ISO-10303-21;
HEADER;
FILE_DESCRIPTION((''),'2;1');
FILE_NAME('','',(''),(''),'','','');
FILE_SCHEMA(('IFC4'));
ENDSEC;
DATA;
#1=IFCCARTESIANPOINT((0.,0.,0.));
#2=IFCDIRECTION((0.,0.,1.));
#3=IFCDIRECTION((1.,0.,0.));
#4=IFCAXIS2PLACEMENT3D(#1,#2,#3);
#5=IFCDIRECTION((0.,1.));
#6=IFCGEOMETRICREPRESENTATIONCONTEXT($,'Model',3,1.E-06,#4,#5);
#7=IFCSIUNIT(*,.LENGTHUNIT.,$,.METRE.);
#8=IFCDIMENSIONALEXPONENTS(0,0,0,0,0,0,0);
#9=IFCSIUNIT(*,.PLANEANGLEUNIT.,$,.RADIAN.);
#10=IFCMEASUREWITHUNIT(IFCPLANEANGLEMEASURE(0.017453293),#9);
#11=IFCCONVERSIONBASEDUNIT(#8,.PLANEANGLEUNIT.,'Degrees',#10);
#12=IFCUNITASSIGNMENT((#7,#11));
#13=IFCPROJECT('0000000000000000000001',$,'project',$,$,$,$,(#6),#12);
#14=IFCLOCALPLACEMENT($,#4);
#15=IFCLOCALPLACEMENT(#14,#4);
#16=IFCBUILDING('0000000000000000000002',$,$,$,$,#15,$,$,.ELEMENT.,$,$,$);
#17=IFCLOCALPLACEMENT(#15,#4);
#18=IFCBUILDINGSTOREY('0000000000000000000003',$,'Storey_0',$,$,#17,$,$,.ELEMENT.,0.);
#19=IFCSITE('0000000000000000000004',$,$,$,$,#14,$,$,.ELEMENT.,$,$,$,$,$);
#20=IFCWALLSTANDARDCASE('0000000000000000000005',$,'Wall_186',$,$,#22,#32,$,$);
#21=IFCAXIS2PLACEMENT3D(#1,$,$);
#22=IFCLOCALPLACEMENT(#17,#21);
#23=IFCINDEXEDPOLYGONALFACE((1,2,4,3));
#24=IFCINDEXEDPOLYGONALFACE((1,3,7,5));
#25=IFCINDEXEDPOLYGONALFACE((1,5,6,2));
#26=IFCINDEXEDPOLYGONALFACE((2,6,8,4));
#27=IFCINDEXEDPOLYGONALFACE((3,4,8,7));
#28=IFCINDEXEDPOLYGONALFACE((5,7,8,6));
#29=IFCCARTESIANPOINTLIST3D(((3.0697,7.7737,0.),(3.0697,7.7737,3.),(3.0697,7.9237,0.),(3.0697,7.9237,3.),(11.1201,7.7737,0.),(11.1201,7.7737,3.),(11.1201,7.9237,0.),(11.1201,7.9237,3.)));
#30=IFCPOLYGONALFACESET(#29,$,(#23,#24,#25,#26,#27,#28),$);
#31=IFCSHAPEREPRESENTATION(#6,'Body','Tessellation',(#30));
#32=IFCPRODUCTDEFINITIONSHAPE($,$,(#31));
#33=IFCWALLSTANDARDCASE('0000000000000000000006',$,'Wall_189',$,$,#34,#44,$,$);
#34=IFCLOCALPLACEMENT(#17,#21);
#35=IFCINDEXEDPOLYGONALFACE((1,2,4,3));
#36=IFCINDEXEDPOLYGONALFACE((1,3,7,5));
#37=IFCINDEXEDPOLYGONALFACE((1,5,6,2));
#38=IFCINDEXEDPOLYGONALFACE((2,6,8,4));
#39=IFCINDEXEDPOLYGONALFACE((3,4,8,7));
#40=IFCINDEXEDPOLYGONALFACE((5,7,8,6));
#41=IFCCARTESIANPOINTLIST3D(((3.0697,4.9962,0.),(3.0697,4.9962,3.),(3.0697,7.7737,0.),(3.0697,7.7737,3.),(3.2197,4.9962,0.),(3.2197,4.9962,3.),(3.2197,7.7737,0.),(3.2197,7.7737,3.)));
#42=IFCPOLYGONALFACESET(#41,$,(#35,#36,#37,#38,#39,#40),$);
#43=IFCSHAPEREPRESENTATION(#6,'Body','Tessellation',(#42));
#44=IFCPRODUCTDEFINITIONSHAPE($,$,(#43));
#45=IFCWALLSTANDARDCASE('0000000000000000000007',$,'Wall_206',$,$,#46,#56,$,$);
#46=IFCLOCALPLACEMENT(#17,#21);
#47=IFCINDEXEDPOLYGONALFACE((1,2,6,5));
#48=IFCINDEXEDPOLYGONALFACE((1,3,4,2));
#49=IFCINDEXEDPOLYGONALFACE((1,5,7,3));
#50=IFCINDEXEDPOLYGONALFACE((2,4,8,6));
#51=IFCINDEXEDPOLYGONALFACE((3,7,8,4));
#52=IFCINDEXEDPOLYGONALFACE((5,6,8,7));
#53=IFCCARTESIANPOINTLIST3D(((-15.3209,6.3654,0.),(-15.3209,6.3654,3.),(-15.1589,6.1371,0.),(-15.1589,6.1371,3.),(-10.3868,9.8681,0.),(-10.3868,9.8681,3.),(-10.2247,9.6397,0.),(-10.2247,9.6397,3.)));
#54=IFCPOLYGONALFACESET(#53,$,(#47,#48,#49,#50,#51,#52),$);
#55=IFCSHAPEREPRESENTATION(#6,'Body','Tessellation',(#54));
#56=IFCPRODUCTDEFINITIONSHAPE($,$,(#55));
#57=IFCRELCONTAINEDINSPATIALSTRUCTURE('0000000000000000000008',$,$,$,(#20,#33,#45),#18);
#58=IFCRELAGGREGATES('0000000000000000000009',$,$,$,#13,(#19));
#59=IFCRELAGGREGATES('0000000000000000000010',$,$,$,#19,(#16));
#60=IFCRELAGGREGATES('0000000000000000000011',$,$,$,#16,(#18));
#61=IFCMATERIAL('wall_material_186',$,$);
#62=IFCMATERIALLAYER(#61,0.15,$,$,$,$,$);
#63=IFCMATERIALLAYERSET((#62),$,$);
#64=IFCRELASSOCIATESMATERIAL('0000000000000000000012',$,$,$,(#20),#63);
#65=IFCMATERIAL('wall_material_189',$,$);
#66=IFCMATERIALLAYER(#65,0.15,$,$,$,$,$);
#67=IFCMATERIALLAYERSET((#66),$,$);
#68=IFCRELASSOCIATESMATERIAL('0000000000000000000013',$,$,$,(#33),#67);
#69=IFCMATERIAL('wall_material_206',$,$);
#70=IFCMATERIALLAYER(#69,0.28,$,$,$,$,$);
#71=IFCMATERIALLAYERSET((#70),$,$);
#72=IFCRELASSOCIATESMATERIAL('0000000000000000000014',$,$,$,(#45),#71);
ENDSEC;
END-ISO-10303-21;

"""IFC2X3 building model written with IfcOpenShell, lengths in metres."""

from ifc_helpers import new_model, entity, si_unit, converted_unit, direction, frame, origin_with_axes, place, context, project, spatial, polyline, outline, extrude, material, layer, layer_set, layer_usage, element, save


model = new_model("IFC2X3")

# Units and contexts
model_context = context("Model", 3, precision=1e-06, world=origin_with_axes(), true_north=direction((0.0, 1.0)))
ifc_project = project(units=[si_unit("LENGTHUNIT", "METRE"), converted_unit("PLANEANGLEUNIT", "Degrees", entity("IfcPlaneAngleMeasure", 0.017453293), si_unit("PLANEANGLEUNIT", "RADIAN"), dimensions=[0, 0, 0, 0, 0, 0, 0])], contexts=[model_context])

# Site, building, storey
site_placement = place(None, origin_with_axes())
site = spatial("IfcSite", under=ifc_project, at=site_placement, CompositionType="ELEMENT")
building_placement = place(site_placement, origin_with_axes())
building = spatial("IfcBuilding", under=site, at=building_placement, CompositionType="ELEMENT")
storey_placement = place(building_placement, origin_with_axes())
storey = spatial("IfcBuildingStorey", under=building, at=storey_placement, Name="Storey_0", CompositionType="ELEMENT", Elevation=0.0)

# Walls
ifc_material_1 = material(Name="wall_material_186")
ifc_layer_1 = layer(ifc_material_1, 0.15)
ifc_layer_set_1 = layer_set([ifc_layer_1])
ifc_layer_usage_1 = layer_usage(ifc_layer_set_1, "AXIS2", "NEGATIVE", 0.0)
wall_1_placement = place(storey_placement, frame((3.0697, 7.9237, 0.0), z_axis=(0.0, 0.0, 1.0), x_axis=(1.0, 0.0, 0.0)))
element("IfcWallStandardCase", 1, at=wall_1_placement, inside=storey, material=ifc_layer_usage_1, Name="Wall_186", context=model_context, shape_type="SweptSolid", body=[
    extrude(outline(polyline([(0.0, 0.0), (8.0504, 0.0), (8.0504, -0.15), (0.0, -0.15), (0.0, 0.0)])), origin_with_axes(), (0.0, 0.0, 1.0), 3.0),
])
ifc_material_2 = material(Name="wall_material_189")
ifc_layer_2 = layer(ifc_material_2, 0.15)
ifc_layer_set_2 = layer_set([ifc_layer_2])
ifc_layer_usage_2 = layer_usage(ifc_layer_set_2, "AXIS2", "NEGATIVE", 0.0)
wall_2_placement = place(storey_placement, frame((3.0697, 4.9962, 0.0), z_axis=(0.0, 0.0, 1.0), x_axis=(0.0, 1.0, 0.0)))
element("IfcWallStandardCase", 2, at=wall_2_placement, inside=storey, material=ifc_layer_usage_2, Name="Wall_189", context=model_context, shape_type="SweptSolid", body=[
    extrude(outline(polyline([(0.0, 0.0), (2.7775, 0.0), (2.7775, -0.15), (0.0, -0.15), (0.0, 0.0)])), origin_with_axes(), (0.0, 0.0, 1.0), 3.0),
])
ifc_material_3 = material(Name="wall_material_206")
ifc_layer_3 = layer(ifc_material_3, 0.28)
ifc_layer_set_3 = layer_set([ifc_layer_3])
ifc_layer_usage_3 = layer_usage(ifc_layer_set_3, "AXIS2", "NEGATIVE", 0.0)
wall_3_placement = place(storey_placement, frame((-10.2247, 9.6397, 0.0), z_axis=(0.0, 0.0, 1.0), x_axis=(-0.815431, -0.578854, 0.0)))
element("IfcWallStandardCase", 3, at=wall_3_placement, inside=storey, material=ifc_layer_usage_3, Name="Wall_206", context=model_context, shape_type="SweptSolid", body=[
    extrude(outline(polyline([(0.0, 0.0), (6.051, 0.0), (6.051, -0.28), (0.0, -0.28), (0.0, 0.0)])), origin_with_axes(), (0.0, 0.0, 1.0), 3.0),
])

save(model, "model.ifc")
